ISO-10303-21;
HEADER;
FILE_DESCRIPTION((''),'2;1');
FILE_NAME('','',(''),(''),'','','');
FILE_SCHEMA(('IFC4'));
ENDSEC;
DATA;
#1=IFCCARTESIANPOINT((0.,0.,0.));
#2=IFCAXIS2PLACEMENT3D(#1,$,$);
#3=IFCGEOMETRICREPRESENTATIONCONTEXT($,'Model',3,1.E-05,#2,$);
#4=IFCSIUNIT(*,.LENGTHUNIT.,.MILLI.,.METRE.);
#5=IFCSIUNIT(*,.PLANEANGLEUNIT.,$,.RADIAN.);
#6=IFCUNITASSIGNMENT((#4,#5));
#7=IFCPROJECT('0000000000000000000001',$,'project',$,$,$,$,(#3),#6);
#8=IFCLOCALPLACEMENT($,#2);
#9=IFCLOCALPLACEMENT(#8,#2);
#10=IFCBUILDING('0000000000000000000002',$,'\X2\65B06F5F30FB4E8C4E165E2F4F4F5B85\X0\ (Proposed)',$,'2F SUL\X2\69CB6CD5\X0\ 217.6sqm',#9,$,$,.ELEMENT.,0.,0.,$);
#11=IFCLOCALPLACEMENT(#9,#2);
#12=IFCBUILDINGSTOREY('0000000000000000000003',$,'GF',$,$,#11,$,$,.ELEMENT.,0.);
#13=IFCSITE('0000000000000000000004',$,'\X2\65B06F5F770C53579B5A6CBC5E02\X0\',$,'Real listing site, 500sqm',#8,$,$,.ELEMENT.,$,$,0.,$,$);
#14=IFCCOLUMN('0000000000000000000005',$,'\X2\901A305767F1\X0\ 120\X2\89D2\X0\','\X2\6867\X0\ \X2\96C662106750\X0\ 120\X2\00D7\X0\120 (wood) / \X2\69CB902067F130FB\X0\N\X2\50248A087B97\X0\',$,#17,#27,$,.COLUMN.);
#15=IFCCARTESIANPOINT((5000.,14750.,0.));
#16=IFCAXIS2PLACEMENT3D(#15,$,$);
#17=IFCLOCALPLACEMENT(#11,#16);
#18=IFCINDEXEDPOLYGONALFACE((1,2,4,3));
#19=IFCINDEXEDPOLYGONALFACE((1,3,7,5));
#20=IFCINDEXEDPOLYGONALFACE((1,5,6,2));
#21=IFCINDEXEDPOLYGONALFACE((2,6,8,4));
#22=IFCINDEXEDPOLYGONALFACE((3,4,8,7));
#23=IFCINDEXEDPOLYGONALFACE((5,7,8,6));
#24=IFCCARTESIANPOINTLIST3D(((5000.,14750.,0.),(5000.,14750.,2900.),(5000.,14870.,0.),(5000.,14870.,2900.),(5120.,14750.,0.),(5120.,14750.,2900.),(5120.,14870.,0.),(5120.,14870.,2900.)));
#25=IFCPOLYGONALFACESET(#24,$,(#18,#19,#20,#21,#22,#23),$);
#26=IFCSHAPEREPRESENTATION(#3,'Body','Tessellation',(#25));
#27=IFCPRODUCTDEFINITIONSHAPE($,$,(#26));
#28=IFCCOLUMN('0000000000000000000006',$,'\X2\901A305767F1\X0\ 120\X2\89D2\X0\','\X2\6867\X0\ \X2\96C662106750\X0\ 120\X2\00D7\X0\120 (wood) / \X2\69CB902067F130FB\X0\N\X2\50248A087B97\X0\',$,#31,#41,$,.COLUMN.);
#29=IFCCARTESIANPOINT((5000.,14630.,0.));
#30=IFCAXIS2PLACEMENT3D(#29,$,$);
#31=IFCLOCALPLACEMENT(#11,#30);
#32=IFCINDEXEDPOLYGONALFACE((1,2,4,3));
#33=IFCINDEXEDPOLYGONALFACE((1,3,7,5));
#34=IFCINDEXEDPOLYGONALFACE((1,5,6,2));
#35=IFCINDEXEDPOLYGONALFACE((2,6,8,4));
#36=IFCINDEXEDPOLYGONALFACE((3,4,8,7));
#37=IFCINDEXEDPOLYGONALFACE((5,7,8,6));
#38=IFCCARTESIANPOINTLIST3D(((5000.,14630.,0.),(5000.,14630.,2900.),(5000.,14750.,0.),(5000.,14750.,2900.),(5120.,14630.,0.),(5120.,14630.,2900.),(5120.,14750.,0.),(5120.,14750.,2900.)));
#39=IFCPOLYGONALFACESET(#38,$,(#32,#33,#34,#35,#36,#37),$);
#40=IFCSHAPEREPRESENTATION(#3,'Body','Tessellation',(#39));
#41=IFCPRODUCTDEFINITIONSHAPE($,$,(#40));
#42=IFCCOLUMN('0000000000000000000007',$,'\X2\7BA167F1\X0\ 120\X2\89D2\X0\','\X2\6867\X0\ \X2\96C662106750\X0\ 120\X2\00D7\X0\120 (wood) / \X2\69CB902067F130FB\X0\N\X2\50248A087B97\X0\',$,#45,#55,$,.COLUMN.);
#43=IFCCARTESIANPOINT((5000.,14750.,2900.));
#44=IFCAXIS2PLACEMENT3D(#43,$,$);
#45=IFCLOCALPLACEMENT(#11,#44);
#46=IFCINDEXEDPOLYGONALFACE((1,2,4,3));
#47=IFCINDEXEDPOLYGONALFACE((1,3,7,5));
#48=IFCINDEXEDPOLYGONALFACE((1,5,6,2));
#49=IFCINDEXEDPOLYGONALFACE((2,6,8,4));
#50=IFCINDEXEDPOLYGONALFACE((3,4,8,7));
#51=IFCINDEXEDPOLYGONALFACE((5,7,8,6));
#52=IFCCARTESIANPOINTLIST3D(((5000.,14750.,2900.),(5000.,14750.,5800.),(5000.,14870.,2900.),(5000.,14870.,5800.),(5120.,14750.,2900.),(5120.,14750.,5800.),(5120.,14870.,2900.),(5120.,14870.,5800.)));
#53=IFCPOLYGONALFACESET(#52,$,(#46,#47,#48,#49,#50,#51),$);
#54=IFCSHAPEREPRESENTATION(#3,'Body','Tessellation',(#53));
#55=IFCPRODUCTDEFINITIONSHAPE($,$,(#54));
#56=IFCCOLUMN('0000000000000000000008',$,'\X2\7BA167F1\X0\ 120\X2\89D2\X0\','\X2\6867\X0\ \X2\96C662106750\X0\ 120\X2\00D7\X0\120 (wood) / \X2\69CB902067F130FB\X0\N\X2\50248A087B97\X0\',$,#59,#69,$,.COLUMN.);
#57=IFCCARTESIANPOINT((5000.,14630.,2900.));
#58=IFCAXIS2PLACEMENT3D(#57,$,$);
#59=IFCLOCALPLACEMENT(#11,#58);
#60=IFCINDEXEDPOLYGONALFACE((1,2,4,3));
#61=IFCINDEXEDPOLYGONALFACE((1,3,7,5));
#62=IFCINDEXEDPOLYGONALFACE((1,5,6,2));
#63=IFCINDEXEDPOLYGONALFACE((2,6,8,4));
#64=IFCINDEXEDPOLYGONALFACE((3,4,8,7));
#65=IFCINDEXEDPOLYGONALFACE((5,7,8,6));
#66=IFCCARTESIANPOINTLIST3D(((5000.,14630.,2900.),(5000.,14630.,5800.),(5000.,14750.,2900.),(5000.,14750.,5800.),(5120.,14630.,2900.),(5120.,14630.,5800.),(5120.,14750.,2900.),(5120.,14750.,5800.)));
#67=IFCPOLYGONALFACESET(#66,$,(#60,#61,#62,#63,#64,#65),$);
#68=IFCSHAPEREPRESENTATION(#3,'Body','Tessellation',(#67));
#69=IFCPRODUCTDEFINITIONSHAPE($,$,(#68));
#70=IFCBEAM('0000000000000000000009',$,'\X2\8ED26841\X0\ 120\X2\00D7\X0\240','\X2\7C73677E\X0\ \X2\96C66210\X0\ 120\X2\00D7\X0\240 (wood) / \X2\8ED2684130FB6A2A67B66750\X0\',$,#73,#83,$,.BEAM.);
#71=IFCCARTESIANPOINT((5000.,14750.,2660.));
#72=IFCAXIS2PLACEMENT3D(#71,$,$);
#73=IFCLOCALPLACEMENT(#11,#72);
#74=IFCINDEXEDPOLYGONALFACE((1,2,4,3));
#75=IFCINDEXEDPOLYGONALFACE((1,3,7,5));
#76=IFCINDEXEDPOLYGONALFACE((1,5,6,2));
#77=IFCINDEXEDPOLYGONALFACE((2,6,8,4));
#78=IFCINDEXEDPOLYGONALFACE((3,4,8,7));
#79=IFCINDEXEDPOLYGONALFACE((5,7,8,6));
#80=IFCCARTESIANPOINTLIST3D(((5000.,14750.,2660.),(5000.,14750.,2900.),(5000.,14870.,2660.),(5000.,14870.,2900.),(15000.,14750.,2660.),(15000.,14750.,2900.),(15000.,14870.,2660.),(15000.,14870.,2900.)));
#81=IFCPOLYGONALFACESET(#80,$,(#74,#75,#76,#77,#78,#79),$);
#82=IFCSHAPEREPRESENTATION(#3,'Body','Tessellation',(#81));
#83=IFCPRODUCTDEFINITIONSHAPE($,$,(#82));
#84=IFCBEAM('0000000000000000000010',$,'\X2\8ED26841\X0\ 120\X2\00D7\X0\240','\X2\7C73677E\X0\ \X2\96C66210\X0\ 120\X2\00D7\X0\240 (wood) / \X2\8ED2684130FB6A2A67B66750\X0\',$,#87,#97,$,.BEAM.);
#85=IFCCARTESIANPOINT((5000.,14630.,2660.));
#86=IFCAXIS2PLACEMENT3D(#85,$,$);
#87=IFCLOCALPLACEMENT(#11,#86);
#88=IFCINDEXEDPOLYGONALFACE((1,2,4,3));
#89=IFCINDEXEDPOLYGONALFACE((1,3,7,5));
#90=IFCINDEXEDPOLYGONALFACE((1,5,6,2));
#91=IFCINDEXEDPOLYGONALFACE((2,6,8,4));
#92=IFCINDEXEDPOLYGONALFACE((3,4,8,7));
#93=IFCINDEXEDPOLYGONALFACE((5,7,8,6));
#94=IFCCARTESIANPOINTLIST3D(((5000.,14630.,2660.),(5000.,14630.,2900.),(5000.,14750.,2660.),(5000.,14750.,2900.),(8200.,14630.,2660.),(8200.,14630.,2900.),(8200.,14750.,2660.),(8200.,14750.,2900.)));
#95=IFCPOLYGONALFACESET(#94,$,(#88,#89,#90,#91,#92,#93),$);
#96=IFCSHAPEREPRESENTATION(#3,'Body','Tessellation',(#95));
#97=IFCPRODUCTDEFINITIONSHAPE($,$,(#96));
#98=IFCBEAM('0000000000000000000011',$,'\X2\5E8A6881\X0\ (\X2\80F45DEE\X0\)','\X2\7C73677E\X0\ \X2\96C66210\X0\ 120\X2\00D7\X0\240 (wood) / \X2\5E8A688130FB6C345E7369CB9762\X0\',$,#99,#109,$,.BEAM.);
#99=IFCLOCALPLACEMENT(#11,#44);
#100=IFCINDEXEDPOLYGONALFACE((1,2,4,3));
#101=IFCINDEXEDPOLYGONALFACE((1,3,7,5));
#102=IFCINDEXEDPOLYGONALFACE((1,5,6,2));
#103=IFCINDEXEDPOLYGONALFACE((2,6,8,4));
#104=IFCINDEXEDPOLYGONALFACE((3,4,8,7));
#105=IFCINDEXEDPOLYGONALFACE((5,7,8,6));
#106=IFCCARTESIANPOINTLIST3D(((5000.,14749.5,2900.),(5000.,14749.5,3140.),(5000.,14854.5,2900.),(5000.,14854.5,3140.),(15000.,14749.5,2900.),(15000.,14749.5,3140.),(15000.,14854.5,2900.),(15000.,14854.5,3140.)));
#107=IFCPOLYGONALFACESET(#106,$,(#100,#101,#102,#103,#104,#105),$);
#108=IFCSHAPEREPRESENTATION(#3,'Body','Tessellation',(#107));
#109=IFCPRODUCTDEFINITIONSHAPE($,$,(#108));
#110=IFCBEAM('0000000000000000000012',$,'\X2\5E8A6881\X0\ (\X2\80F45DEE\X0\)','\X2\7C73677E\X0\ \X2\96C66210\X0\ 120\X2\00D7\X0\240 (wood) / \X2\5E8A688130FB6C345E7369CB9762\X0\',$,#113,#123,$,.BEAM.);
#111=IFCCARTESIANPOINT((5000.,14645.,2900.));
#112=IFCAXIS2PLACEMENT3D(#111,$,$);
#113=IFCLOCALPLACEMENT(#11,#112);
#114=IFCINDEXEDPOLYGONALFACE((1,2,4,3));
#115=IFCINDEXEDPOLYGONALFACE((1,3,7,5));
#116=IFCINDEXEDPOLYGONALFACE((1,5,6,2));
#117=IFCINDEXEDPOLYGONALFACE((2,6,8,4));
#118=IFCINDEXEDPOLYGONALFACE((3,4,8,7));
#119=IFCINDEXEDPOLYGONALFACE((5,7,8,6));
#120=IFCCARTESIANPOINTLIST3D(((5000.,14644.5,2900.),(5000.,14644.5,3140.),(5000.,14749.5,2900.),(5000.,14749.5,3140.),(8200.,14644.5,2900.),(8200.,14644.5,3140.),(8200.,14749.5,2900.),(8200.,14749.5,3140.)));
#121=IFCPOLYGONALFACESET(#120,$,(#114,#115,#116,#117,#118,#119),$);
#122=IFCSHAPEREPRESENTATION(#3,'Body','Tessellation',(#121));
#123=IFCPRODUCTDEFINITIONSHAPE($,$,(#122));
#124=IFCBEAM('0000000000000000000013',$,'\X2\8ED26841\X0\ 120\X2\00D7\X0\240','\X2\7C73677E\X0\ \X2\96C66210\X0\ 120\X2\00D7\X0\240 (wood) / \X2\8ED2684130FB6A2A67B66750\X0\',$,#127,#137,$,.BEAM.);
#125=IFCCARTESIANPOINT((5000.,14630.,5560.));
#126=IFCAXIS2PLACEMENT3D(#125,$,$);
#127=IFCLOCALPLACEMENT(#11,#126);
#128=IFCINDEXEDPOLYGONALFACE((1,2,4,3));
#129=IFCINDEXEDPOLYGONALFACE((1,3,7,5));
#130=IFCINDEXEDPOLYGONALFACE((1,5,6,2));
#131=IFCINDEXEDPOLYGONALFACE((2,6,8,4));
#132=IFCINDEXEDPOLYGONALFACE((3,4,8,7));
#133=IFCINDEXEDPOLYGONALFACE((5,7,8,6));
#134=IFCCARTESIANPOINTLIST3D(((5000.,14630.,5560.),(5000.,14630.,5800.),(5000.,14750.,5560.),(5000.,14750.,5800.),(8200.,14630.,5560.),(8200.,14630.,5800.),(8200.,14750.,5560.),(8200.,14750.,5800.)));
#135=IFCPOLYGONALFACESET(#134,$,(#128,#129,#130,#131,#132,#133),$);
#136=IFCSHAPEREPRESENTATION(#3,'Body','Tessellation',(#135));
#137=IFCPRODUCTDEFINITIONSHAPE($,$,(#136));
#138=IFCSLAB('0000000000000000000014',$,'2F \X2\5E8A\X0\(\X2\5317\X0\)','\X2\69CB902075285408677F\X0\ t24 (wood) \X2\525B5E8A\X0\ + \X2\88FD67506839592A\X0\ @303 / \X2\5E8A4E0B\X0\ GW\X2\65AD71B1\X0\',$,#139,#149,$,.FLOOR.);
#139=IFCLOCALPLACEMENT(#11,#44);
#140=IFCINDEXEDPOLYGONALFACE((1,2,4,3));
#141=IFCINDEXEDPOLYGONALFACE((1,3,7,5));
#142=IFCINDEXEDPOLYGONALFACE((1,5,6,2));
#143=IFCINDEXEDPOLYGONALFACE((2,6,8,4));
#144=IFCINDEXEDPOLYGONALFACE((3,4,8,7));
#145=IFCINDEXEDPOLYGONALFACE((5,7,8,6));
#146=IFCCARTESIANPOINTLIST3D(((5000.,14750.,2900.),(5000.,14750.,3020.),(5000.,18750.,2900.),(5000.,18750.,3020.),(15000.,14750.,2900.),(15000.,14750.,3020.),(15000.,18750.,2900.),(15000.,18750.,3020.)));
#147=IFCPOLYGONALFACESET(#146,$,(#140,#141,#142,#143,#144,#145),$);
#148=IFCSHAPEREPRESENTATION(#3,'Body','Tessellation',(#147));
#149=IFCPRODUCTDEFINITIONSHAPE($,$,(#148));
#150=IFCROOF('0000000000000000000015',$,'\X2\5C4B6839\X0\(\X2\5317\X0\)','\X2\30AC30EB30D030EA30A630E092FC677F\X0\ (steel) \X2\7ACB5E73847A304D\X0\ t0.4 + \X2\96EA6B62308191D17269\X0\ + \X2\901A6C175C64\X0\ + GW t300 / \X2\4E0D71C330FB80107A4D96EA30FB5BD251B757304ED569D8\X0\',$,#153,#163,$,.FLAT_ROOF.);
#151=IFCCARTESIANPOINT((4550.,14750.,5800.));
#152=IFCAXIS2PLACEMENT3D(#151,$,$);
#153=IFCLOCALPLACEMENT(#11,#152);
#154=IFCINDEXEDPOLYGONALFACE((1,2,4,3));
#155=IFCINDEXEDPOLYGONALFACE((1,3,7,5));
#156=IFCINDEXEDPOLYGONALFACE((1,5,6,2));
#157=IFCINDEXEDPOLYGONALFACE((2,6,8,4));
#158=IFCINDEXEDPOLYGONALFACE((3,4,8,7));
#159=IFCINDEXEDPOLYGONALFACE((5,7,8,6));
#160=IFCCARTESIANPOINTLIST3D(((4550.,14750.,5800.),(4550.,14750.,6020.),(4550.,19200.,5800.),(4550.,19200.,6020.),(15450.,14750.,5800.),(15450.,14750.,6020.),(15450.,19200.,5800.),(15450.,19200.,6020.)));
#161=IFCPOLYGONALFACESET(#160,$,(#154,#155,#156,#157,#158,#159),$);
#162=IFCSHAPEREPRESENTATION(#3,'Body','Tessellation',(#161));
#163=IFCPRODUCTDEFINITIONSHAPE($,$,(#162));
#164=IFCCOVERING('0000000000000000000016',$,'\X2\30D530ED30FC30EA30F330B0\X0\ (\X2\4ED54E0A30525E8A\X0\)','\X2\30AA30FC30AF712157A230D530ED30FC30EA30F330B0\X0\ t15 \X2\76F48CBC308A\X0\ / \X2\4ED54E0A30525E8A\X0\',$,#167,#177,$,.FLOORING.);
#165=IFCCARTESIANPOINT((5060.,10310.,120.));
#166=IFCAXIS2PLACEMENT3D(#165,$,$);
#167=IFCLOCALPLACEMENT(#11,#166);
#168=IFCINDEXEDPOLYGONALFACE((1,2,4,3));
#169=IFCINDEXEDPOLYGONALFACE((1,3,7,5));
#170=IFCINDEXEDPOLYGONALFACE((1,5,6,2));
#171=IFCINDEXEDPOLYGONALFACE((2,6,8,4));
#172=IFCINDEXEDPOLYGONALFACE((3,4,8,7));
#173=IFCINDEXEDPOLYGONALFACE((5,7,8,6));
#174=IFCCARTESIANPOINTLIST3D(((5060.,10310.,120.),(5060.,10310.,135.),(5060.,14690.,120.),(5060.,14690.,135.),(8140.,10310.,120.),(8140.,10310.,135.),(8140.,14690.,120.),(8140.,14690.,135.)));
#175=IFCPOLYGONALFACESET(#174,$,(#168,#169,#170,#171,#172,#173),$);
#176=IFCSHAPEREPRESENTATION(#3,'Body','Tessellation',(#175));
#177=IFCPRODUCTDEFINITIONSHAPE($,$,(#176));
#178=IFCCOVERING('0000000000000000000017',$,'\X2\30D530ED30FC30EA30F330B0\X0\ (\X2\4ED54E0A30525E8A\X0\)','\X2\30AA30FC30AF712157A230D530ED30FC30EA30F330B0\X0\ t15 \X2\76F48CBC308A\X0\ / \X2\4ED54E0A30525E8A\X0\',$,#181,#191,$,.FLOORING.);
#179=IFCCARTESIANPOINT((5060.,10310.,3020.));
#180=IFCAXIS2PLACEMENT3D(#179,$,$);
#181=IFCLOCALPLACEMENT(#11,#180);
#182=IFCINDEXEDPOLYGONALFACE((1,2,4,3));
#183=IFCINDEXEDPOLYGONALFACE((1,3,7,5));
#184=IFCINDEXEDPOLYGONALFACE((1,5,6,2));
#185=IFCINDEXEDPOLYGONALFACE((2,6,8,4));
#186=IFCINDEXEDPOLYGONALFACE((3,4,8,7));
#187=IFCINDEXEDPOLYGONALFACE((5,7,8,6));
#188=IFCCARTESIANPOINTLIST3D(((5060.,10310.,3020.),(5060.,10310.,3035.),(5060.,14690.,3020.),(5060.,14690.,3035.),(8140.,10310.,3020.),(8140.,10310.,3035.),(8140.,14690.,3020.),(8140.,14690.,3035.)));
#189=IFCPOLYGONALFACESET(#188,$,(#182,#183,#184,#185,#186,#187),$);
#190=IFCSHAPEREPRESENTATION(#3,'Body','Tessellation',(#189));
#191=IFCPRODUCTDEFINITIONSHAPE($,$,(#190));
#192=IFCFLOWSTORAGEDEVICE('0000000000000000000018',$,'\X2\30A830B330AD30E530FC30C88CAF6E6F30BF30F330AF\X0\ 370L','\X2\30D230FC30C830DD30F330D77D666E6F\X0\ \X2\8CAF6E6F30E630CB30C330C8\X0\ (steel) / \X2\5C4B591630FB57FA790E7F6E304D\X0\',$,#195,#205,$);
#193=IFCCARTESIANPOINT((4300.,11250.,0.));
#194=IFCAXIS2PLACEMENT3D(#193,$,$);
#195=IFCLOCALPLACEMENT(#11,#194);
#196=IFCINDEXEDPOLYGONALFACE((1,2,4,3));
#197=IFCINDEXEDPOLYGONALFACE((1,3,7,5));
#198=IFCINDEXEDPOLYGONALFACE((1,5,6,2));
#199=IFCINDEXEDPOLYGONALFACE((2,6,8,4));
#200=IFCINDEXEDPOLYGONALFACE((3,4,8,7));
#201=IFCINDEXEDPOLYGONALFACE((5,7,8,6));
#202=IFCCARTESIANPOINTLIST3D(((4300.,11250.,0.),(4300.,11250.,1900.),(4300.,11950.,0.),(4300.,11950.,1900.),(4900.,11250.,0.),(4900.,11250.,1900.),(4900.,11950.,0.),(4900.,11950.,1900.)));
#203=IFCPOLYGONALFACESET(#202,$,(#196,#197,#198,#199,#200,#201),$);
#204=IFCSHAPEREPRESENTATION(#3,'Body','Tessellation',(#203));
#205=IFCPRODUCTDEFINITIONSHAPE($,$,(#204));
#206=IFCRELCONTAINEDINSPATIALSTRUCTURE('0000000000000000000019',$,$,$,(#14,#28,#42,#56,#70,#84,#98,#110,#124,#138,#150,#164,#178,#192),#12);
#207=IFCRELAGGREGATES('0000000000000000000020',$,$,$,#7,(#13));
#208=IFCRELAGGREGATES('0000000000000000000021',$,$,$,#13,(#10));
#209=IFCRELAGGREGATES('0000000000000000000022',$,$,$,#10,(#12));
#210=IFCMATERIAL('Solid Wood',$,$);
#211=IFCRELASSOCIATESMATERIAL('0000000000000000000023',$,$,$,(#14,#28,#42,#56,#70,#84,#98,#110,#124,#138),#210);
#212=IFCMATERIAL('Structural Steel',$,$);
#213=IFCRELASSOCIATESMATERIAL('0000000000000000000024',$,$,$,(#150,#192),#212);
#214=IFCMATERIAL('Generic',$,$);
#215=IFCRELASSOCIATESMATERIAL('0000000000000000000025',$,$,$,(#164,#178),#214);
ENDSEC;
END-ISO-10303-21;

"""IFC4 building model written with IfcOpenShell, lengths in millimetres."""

from ifc_helpers import new_model, si_unit, frame, frame_2d, origin, place, context, project, spatial, rectangle, extrude, material, element, save


model = new_model("IFC4")

# Units and contexts
model_context = context("Model", 3, precision=1e-05, world=origin())
ifc_project = project(units=[si_unit("LENGTHUNIT", "METRE", prefix="MILLI"), si_unit("PLANEANGLEUNIT", "RADIAN")], contexts=[model_context])

# Site, building, storey
site_placement = place(None, origin())
site = spatial("IfcSite", under=ifc_project, at=site_placement, Name="新潟県南魚沼市", ObjectType="Real listing site, 500sqm", CompositionType="ELEMENT", RefElevation=0.0)
building_placement = place(site_placement, origin())
building = spatial("IfcBuilding", under=site, at=building_placement, Name="新潟・二世帯住宅 (Proposed)", ObjectType="2F SUL構法 217.6sqm", CompositionType="ELEMENT", ElevationOfRefHeight=0.0, ElevationOfTerrain=0.0)
storey_placement = place(building_placement, origin())
storey = spatial("IfcBuildingStorey", under=building, at=storey_placement, Name="GF", CompositionType="ELEMENT", Elevation=0.0)

# Columns
ifc_material_1 = material(Name="Solid Wood")
column_1_placement = place(storey_placement, frame((5000.0, 14750.0, 0.0)))
element("IfcColumn", 1, at=column_1_placement, inside=storey, material=ifc_material_1, Name="通し柱 120角", Description="桧 集成材 120×120 (wood) / 構造柱・N値計算", PredefinedType="COLUMN", context=model_context, shape_type="SweptSolid", body=[
    extrude(rectangle(XDim=120.0, YDim=120.0, at=frame_2d((60.0, 60.0))), frame((5000.0, 14750.0, 0.0)), (0.0, 0.0, 1.0), 2900.0),
])
column_2_placement = place(storey_placement, frame((5000.0, 14630.0, 0.0)))
element("IfcColumn", 2, at=column_2_placement, inside=storey, material=ifc_material_1, Name="通し柱 120角", Description="桧 集成材 120×120 (wood) / 構造柱・N値計算", PredefinedType="COLUMN", context=model_context, shape_type="SweptSolid", body=[
    extrude(rectangle(XDim=120.0, YDim=120.0, at=frame_2d((60.0, 60.0))), frame((5000.0, 14630.0, 0.0)), (0.0, 0.0, 1.0), 2900.0),
])
column_3_placement = place(storey_placement, frame((5000.0, 14750.0, 2900.0)))
element("IfcColumn", 3, at=column_3_placement, inside=storey, material=ifc_material_1, Name="管柱 120角", Description="桧 集成材 120×120 (wood) / 構造柱・N値計算", PredefinedType="COLUMN", context=model_context, shape_type="SweptSolid", body=[
    extrude(rectangle(XDim=120.0, YDim=120.0, at=frame_2d((60.0, 60.0))), frame((5000.0, 14750.0, 2900.0)), (0.0, 0.0, 1.0), 2900.0),
])
column_4_placement = place(storey_placement, frame((5000.0, 14630.0, 2900.0)))
element("IfcColumn", 4, at=column_4_placement, inside=storey, material=ifc_material_1, Name="管柱 120角", Description="桧 集成材 120×120 (wood) / 構造柱・N値計算", PredefinedType="COLUMN", context=model_context, shape_type="SweptSolid", body=[
    extrude(rectangle(XDim=120.0, YDim=120.0, at=frame_2d((60.0, 60.0))), frame((5000.0, 14630.0, 2900.0)), (0.0, 0.0, 1.0), 2900.0),
])

# Beams
beam_1_placement = place(storey_placement, frame((5000.0, 14750.0, 2660.0)))
element("IfcBeam", 5, at=beam_1_placement, inside=storey, material=ifc_material_1, Name="軒桁 120×240", Description="米松 集成 120×240 (wood) / 軒桁・横架材", PredefinedType="BEAM", context=model_context, shape_type="SweptSolid", body=[
    extrude(rectangle(XDim=10000.0, YDim=120.0, at=frame_2d((5000.0, 60.0))), frame((5000.0, 14750.0, 2660.0)), (0.0, 0.0, 1.0), 240.0),
])
beam_2_placement = place(storey_placement, frame((5000.0, 14630.0, 2660.0)))
element("IfcBeam", 6, at=beam_2_placement, inside=storey, material=ifc_material_1, Name="軒桁 120×240", Description="米松 集成 120×240 (wood) / 軒桁・横架材", PredefinedType="BEAM", context=model_context, shape_type="SweptSolid", body=[
    extrude(rectangle(XDim=3200.0, YDim=120.0, at=frame_2d((1600.0, 60.0))), frame((5000.0, 14630.0, 2660.0)), (0.0, 0.0, 1.0), 240.0),
])
beam_3_placement = place(storey_placement, frame((5000.0, 14750.0, 2900.0)))
element("IfcBeam", 7, at=beam_3_placement, inside=storey, material=ifc_material_1, Name="床梁 (胴差)", Description="米松 集成 120×240 (wood) / 床梁・水平構面", PredefinedType="BEAM", context=model_context, shape_type="SweptSolid", body=[
    extrude(rectangle(XDim=10000.0, YDim=105.0, at=frame_2d((5000.0, 52.0))), frame((5000.0, 14750.0, 2900.0)), (0.0, 0.0, 1.0), 240.0),
])
beam_4_placement = place(storey_placement, frame((5000.0, 14645.0, 2900.0)))
element("IfcBeam", 8, at=beam_4_placement, inside=storey, material=ifc_material_1, Name="床梁 (胴差)", Description="米松 集成 120×240 (wood) / 床梁・水平構面", PredefinedType="BEAM", context=model_context, shape_type="SweptSolid", body=[
    extrude(rectangle(XDim=3200.0, YDim=105.0, at=frame_2d((1600.0, 52.0))), frame((5000.0, 14645.0, 2900.0)), (0.0, 0.0, 1.0), 240.0),
])
beam_5_placement = place(storey_placement, frame((5000.0, 14630.0, 5560.0)))
element("IfcBeam", 9, at=beam_5_placement, inside=storey, material=ifc_material_1, Name="軒桁 120×240", Description="米松 集成 120×240 (wood) / 軒桁・横架材", PredefinedType="BEAM", context=model_context, shape_type="SweptSolid", body=[
    extrude(rectangle(XDim=3200.0, YDim=120.0, at=frame_2d((1600.0, 60.0))), frame((5000.0, 14630.0, 5560.0)), (0.0, 0.0, 1.0), 240.0),
])

# Slab
slab_1_placement = place(storey_placement, frame((5000.0, 14750.0, 2900.0)))
element("IfcSlab", 10, at=slab_1_placement, inside=storey, material=ifc_material_1, Name="2F 床(北)", Description="構造用合板 t24 (wood) 剛床 + 製材根太 @303 / 床下 GW断熱", PredefinedType="FLOOR", context=model_context, shape_type="SweptSolid", body=[
    extrude(rectangle(XDim=10000.0, YDim=4000.0, at=frame_2d((5000.0, 2000.0))), frame((5000.0, 14750.0, 2900.0)), (0.0, 0.0, 1.0), 120.0),
])

# Roof
ifc_material_2 = material(Name="Structural Steel")
for number, where, name in (
    (11, (4550.0, 14750.0, 5800.0), "屋根(北)"),
):
    element("IfcRoof", number, at=place(storey_placement, frame(where)), inside=storey, material=ifc_material_2, Name=name, Description="ガルバリウム鋼板 (steel) 立平葺き t0.4 + 雪止め金物 + 通気層 + GW t300 / 不燃・耐積雪・寒冷地仕様", PredefinedType="FLAT_ROOF", context=model_context, shape_type="SweptSolid", body=[
        extrude(rectangle(XDim=10900.0, YDim=4450.0, at=frame_2d((5450.0, 2225.0))), frame((4550.0, 14750.0, 5800.0)), (0.0, 0.0, 1.0), 220.0),
    ])

# Coverings
ifc_material_3 = material(Name="Generic")
covering_1_placement = place(storey_placement, frame((5060.0, 10310.0, 120.0)))
element("IfcCovering", 12, at=covering_1_placement, inside=storey, material=ifc_material_3, Name="フローリング (仕上げ床)", Description="オーク無垢フローリング t15 直貼り / 仕上げ床", PredefinedType="FLOORING", context=model_context, shape_type="SweptSolid", body=[
    extrude(rectangle(XDim=3080.0, YDim=4380.0, at=frame_2d((1540.0, 2190.0))), frame((5060.0, 10310.0, 120.0)), (0.0, 0.0, 1.0), 15.0),
])
covering_2_placement = place(storey_placement, frame((5060.0, 10310.0, 3020.0)))
element("IfcCovering", 13, at=covering_2_placement, inside=storey, material=ifc_material_3, Name="フローリング (仕上げ床)", Description="オーク無垢フローリング t15 直貼り / 仕上げ床", PredefinedType="FLOORING", context=model_context, shape_type="SweptSolid", body=[
    extrude(rectangle(XDim=3080.0, YDim=4380.0, at=frame_2d((1540.0, 2190.0))), frame((5060.0, 10310.0, 3020.0)), (0.0, 0.0, 1.0), 15.0),
])

# Flow storage device
flow_storage_device_placement = place(storey_placement, frame((4300.0, 11250.0, 0.0)))
element("IfcFlowStorageDevice", 14, at=flow_storage_device_placement, inside=storey, material=ifc_material_2, Name="エコキュート貯湯タンク 370L", Description="ヒートポンプ給湯 貯湯ユニット (steel) / 屋外・基礎置き", context=model_context, shape_type="SweptSolid", body=[
    extrude(rectangle(XDim=600.0, YDim=700.0, at=frame_2d((300.0, 350.0))), frame((4300.0, 11250.0, 0.0)), (0.0, 0.0, 1.0), 1900.0),
])

save(model, "model.ifc")
